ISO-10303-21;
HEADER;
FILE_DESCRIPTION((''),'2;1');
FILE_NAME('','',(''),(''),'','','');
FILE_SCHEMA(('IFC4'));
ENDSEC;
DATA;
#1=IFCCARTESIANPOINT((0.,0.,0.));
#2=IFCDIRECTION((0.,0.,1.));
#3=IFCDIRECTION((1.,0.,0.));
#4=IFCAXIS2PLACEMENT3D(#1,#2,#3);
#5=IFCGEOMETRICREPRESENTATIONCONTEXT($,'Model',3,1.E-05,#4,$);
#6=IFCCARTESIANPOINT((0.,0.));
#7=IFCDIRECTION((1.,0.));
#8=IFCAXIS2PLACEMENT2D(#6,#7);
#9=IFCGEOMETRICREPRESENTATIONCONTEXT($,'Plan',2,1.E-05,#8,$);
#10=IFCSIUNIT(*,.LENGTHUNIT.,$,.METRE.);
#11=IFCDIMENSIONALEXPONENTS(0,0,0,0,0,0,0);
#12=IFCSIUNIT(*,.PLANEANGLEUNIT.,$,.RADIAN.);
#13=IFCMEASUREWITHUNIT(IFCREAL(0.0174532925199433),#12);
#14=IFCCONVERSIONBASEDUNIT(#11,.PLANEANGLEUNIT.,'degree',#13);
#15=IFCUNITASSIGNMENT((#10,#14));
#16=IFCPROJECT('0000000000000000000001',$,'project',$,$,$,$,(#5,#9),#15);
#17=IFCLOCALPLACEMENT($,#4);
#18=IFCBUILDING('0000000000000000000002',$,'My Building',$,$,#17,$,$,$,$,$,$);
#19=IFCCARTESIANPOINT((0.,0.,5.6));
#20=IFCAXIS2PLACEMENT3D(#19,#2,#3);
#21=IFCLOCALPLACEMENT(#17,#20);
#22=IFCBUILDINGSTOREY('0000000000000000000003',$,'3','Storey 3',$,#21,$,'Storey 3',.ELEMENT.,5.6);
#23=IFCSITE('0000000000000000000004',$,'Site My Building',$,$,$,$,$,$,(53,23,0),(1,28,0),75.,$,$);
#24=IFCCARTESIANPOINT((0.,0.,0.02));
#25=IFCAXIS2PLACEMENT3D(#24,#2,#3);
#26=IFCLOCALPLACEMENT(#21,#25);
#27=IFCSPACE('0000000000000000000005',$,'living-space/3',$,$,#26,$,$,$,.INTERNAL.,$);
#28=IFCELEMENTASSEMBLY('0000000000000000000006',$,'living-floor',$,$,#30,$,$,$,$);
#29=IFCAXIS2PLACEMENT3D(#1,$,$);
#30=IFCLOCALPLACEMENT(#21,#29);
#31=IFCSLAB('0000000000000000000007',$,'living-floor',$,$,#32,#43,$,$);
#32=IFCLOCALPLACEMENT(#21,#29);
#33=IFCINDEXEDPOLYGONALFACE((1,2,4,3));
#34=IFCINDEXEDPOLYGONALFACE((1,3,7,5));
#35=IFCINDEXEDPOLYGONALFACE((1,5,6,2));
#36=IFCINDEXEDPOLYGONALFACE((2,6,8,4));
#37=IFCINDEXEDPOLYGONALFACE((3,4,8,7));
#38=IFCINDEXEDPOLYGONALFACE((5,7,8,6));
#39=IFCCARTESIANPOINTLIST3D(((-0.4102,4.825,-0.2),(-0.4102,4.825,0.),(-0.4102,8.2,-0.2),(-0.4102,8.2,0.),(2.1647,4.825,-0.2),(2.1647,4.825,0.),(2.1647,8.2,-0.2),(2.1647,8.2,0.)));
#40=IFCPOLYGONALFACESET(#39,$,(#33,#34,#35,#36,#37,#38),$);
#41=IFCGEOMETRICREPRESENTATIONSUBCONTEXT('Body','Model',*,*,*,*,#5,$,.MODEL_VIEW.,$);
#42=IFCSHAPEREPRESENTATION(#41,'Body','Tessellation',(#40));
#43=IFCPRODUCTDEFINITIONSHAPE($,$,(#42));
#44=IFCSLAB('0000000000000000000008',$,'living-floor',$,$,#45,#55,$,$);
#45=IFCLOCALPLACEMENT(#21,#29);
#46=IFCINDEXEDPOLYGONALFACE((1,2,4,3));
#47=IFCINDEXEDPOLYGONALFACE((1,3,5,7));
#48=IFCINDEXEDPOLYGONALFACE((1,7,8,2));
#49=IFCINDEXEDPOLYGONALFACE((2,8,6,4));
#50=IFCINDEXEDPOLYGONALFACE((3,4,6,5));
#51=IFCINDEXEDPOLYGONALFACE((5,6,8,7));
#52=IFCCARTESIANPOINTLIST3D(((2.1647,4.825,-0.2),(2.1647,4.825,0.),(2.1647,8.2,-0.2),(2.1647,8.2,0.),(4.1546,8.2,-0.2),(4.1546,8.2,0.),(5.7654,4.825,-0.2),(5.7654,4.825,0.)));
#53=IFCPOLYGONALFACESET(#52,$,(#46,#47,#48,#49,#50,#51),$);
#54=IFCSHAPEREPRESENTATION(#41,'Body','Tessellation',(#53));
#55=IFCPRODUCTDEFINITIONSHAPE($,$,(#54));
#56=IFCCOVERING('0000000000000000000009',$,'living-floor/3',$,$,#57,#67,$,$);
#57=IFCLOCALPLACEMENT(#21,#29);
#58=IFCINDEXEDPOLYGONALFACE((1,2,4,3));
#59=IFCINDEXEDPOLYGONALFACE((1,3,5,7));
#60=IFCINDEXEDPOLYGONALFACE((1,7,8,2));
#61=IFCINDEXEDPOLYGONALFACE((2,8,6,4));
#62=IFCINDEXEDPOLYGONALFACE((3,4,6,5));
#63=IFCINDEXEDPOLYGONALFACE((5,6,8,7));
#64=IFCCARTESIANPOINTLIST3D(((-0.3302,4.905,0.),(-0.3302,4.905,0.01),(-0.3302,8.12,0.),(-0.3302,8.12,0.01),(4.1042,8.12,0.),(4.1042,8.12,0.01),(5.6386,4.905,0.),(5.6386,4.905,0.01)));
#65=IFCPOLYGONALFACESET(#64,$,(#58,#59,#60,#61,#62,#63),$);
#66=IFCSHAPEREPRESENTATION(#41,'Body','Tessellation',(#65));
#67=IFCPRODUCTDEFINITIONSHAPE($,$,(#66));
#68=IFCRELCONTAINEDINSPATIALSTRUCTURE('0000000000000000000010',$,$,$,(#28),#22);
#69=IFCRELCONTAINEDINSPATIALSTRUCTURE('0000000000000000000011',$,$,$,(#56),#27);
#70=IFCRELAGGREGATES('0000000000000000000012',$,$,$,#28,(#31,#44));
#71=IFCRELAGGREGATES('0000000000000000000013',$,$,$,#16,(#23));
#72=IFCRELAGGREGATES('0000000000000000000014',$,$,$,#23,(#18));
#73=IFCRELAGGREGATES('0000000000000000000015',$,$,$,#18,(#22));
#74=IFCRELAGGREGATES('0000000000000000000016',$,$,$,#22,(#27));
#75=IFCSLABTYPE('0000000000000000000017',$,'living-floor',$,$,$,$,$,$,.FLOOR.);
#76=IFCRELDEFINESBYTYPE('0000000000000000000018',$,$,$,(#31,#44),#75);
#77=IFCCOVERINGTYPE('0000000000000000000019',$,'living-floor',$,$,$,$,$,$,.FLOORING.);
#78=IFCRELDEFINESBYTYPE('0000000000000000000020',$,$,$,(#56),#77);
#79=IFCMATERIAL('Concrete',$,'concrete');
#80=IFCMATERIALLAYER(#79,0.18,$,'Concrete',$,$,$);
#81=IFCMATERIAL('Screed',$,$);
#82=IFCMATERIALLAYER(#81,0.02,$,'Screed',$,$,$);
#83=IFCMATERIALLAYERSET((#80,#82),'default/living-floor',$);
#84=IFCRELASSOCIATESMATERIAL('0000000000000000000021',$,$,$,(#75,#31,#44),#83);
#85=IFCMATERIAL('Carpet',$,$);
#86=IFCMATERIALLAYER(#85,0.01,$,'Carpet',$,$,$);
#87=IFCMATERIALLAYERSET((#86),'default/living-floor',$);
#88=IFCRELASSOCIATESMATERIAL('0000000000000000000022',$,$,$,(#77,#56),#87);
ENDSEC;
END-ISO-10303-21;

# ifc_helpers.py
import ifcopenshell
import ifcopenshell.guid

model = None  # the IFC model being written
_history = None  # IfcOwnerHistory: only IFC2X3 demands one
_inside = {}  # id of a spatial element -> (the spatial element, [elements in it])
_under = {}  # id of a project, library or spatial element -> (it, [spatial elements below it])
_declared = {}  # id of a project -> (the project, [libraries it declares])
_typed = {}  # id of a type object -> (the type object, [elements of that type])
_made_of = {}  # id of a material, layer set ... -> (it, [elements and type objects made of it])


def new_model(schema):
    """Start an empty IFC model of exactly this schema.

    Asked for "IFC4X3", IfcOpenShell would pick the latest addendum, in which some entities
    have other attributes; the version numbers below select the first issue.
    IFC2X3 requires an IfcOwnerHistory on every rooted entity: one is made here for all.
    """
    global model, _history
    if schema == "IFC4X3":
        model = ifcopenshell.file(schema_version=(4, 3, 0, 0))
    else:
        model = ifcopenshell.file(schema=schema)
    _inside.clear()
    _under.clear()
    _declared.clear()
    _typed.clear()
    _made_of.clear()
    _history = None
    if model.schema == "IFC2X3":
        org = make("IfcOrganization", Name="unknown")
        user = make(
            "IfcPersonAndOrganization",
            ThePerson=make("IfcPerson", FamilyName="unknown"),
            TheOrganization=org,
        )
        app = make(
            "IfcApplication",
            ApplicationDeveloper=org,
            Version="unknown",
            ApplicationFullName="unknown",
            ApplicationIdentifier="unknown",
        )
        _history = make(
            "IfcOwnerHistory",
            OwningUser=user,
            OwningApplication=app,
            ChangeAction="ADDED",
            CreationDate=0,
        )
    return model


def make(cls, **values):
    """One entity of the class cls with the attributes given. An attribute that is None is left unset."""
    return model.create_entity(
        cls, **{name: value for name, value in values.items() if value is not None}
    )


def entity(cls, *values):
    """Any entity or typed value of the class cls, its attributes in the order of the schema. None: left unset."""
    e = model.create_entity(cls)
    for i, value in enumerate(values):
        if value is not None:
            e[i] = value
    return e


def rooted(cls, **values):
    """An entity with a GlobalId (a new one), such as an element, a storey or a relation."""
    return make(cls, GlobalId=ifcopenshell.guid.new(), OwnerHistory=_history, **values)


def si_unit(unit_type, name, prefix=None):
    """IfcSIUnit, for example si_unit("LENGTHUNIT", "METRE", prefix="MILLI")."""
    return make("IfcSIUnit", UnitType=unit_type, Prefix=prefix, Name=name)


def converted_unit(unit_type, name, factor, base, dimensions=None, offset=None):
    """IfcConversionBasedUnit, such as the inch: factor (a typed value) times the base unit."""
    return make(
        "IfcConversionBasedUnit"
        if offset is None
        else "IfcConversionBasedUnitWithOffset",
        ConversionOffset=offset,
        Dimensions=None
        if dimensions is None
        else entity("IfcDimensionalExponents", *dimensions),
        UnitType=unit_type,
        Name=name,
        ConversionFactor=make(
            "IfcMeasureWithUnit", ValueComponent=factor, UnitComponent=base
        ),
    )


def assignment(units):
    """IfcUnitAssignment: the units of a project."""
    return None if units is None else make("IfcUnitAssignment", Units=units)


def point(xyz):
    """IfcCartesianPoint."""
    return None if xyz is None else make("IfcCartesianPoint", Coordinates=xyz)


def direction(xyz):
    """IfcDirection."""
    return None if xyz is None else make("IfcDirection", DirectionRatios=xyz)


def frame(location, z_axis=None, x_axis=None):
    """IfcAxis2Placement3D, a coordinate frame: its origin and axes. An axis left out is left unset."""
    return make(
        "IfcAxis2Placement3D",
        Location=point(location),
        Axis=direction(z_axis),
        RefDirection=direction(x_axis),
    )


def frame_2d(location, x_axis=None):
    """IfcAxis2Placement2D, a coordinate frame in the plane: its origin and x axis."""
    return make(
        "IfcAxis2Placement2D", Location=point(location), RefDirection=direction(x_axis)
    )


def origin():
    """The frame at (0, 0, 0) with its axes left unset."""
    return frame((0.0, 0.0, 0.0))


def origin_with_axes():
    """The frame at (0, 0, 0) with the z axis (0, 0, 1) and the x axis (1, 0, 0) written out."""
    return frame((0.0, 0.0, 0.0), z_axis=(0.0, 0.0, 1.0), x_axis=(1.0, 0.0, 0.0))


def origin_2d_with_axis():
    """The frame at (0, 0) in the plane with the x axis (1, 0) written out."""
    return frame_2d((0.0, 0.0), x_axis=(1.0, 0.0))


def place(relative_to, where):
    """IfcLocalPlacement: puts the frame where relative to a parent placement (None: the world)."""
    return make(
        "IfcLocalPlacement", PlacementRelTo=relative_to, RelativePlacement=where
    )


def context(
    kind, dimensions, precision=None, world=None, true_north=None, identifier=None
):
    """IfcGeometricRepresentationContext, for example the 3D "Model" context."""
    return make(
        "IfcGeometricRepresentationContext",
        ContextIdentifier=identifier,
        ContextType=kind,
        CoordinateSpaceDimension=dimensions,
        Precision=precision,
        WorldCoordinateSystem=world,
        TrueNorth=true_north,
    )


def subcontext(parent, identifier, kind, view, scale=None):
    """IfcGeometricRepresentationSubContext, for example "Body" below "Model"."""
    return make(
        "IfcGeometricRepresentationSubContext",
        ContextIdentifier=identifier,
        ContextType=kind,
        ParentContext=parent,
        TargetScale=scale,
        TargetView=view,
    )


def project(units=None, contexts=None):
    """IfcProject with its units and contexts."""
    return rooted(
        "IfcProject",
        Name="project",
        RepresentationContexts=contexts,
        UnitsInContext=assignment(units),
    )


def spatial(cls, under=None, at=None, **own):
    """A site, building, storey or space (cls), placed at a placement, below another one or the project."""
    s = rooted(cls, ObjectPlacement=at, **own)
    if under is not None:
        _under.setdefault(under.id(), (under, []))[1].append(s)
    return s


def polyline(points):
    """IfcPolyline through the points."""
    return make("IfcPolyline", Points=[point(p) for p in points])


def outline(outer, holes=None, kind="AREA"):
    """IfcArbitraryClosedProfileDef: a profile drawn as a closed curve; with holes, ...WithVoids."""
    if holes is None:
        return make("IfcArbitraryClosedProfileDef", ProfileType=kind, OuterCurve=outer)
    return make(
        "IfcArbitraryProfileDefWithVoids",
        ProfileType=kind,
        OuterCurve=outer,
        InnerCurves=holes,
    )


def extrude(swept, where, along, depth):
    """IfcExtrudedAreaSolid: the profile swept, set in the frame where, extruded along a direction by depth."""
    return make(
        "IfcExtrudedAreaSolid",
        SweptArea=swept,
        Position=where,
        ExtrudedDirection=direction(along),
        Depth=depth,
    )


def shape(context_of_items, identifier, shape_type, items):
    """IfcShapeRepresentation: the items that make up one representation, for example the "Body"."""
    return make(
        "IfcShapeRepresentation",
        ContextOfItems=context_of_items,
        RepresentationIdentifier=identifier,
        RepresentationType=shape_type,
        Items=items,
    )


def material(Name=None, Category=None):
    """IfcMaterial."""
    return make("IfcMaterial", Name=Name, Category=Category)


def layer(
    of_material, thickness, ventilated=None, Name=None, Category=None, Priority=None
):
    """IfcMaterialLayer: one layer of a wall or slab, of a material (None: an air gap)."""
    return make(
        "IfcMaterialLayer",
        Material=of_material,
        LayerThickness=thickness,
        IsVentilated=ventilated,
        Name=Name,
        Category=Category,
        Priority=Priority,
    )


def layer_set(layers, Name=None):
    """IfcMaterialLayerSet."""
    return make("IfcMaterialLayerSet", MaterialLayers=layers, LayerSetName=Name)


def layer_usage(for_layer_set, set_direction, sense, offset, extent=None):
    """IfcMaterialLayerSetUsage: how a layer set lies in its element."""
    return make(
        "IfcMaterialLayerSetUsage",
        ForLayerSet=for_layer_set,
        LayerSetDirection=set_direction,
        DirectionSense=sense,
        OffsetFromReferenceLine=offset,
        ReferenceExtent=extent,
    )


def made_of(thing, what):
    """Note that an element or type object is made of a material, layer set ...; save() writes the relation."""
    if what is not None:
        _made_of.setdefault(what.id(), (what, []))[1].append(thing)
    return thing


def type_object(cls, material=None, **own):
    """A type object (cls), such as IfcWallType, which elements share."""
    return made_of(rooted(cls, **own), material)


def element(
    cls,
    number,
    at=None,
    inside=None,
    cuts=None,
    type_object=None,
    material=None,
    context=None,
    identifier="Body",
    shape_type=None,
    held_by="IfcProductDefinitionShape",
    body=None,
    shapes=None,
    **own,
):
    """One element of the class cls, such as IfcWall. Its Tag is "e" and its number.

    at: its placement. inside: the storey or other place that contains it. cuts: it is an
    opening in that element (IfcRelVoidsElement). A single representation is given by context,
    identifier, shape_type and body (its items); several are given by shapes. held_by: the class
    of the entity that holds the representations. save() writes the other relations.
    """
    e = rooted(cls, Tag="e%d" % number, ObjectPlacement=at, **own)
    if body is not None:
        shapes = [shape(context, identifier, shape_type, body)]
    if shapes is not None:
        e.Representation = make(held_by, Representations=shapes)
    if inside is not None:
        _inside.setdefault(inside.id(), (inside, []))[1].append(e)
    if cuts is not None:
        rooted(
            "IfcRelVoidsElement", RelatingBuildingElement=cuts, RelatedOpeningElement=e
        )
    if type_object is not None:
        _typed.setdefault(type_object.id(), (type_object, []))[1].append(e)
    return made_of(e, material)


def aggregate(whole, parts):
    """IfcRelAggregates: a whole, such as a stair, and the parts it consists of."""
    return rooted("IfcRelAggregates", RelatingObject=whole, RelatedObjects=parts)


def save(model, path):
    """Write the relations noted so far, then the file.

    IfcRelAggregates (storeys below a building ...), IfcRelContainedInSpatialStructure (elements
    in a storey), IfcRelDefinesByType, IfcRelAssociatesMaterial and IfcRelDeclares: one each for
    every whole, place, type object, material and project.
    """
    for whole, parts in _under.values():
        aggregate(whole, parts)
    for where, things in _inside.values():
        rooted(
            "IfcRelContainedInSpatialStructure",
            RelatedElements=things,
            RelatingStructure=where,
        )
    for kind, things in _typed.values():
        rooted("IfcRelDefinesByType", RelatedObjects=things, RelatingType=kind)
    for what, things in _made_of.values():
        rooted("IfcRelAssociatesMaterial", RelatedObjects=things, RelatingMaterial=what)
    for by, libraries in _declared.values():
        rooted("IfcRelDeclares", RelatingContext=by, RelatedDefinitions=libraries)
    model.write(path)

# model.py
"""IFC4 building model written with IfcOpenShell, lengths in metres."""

from ifc_helpers import new_model, entity, si_unit, converted_unit, frame, origin, origin_with_axes, origin_2d_with_axis, place, context, subcontext, project, spatial, polyline, outline, extrude, material, layer, layer_set, layer_usage, type_object, element, aggregate, save


model = new_model("IFC4")

# Units and contexts
model_context = context("Model", 3, precision=1e-05, world=origin_with_axes())
plan_context = context("Plan", 2, precision=1e-05, world=origin_2d_with_axis())
body_context = subcontext(model_context, "Body", "Model", "MODEL_VIEW")
ifc_project = project(units=[si_unit("LENGTHUNIT", "METRE"), converted_unit("PLANEANGLEUNIT", "degree", entity("IfcReal", 0.0174532925199433), si_unit("PLANEANGLEUNIT", "RADIAN"), dimensions=[0, 0, 0, 0, 0, 0, 0])], contexts=[model_context, plan_context])

# Site, building, storey
site = spatial("IfcSite", under=ifc_project, Name="Site My Building", RefLatitude=(53, 23, 0), RefLongitude=(1, 28, 0), RefElevation=75.0)
building_placement = place(None, origin_with_axes())
building = spatial("IfcBuilding", under=site, at=building_placement, Name="My Building")
storey_placement = place(building_placement, frame((0.0, 0.0, 5.6), z_axis=(0.0, 0.0, 1.0), x_axis=(1.0, 0.0, 0.0)))
storey = spatial("IfcBuildingStorey", under=building, at=storey_placement, Name="3", Description="Storey 3", LongName="Storey 3", CompositionType="ELEMENT", Elevation=5.6)

# Element assembly, slabs
assembly_placement = place(storey_placement, frame((0.0, 0.0, -5.6), z_axis=(0.0, 0.0, 1.0), x_axis=(1.0, 0.0, 0.0)))
assembly = element("IfcElementAssembly", 1, at=assembly_placement, inside=storey, Name="living-floor")
ifc_material_1 = material(Name="Concrete", Category="concrete")
ifc_layer_1 = layer(ifc_material_1, 0.18, Name="Concrete")
ifc_material_2 = material(Name="Screed")
ifc_layer_2 = layer(ifc_material_2, 0.02, Name="Screed")
ifc_layer_set_1 = layer_set([ifc_layer_1, ifc_layer_2], Name="default/living-floor")
ifc_layer_usage_1 = layer_usage(ifc_layer_set_1, "AXIS3", "POSITIVE", 0.0)
slab_type = type_object("IfcSlabType", Name="living-floor", PredefinedType="FLOOR", material=ifc_layer_set_1)
slab_1_placement = place(assembly_placement, frame((2.1647, 8.2, 5.4), z_axis=(0.0, 0.0, 1.0), x_axis=(1.0, 0.0, 0.0)))
slab_1 = element("IfcSlab", 2, at=slab_1_placement, type_object=slab_type, material=ifc_layer_usage_1, Name="living-floor", context=body_context, shape_type="SweptSolid", body=[
    extrude(outline(polyline([(0.0, 0.0), (0.0, -3.375), (-2.5749, -3.375), (-2.5749, 0.0), (0.0, 0.0)])), origin(), (0.0, 0.0, 1.0), 0.2),
])
ifc_layer_usage_2 = layer_usage(ifc_layer_set_1, "AXIS3", "POSITIVE", 0.0)
slab_2_placement = place(assembly_placement, frame((2.1647, 8.2, 5.4), z_axis=(0.0, 0.0, 1.0), x_axis=(1.0, 0.0, 0.0)))
slab_2 = element("IfcSlab", 3, at=slab_2_placement, type_object=slab_type, material=ifc_layer_usage_2, Name="living-floor", context=body_context, shape_type="SweptSolid", body=[
    extrude(outline(polyline([(0.0, 0.0), (1.99, 0.0), (3.6007, -3.375), (0.0, -3.375), (0.0, 0.0)])), origin(), (0.0, 0.0, 1.0), 0.2),
])
aggregate(assembly, [slab_1, slab_2])

# Shared definitions
space_placement = place(storey_placement, frame((0.0, 0.0, 0.02), z_axis=(0.0, 0.0, 1.0), x_axis=(1.0, 0.0, 0.0)))
space = spatial("IfcSpace", under=storey, at=space_placement, Name="living-space/3", PredefinedType="INTERNAL")

# Covering
ifc_material_3 = material(Name="Carpet")
ifc_layer_3 = layer(ifc_material_3, 0.01, Name="Carpet")
ifc_layer_set_2 = layer_set([ifc_layer_3], Name="default/living-floor")
ifc_layer_usage_3 = layer_usage(ifc_layer_set_2, "AXIS2", "POSITIVE", 0.0)
covering_type = type_object("IfcCoveringType", Name="living-floor", PredefinedType="FLOORING", material=ifc_layer_set_2)
covering_placement = place(space_placement, frame((0.0, 0.0, -0.02), z_axis=(0.0, 0.0, 1.0), x_axis=(1.0, 0.0, 0.0)))
element("IfcCovering", 4, at=covering_placement, inside=space, type_object=covering_type, material=ifc_layer_usage_3, Name="living-floor/3", context=body_context, shape_type="SweptSolid", body=[
    extrude(outline(polyline([(5.6386, 4.905), (4.1042, 8.12), (-0.3302, 8.12), (-0.3302, 4.905), (5.6386, 4.905)])), origin_with_axes(), (0.0, 0.0, 1.0), 0.01),
])

save(model, "model.ifc")
